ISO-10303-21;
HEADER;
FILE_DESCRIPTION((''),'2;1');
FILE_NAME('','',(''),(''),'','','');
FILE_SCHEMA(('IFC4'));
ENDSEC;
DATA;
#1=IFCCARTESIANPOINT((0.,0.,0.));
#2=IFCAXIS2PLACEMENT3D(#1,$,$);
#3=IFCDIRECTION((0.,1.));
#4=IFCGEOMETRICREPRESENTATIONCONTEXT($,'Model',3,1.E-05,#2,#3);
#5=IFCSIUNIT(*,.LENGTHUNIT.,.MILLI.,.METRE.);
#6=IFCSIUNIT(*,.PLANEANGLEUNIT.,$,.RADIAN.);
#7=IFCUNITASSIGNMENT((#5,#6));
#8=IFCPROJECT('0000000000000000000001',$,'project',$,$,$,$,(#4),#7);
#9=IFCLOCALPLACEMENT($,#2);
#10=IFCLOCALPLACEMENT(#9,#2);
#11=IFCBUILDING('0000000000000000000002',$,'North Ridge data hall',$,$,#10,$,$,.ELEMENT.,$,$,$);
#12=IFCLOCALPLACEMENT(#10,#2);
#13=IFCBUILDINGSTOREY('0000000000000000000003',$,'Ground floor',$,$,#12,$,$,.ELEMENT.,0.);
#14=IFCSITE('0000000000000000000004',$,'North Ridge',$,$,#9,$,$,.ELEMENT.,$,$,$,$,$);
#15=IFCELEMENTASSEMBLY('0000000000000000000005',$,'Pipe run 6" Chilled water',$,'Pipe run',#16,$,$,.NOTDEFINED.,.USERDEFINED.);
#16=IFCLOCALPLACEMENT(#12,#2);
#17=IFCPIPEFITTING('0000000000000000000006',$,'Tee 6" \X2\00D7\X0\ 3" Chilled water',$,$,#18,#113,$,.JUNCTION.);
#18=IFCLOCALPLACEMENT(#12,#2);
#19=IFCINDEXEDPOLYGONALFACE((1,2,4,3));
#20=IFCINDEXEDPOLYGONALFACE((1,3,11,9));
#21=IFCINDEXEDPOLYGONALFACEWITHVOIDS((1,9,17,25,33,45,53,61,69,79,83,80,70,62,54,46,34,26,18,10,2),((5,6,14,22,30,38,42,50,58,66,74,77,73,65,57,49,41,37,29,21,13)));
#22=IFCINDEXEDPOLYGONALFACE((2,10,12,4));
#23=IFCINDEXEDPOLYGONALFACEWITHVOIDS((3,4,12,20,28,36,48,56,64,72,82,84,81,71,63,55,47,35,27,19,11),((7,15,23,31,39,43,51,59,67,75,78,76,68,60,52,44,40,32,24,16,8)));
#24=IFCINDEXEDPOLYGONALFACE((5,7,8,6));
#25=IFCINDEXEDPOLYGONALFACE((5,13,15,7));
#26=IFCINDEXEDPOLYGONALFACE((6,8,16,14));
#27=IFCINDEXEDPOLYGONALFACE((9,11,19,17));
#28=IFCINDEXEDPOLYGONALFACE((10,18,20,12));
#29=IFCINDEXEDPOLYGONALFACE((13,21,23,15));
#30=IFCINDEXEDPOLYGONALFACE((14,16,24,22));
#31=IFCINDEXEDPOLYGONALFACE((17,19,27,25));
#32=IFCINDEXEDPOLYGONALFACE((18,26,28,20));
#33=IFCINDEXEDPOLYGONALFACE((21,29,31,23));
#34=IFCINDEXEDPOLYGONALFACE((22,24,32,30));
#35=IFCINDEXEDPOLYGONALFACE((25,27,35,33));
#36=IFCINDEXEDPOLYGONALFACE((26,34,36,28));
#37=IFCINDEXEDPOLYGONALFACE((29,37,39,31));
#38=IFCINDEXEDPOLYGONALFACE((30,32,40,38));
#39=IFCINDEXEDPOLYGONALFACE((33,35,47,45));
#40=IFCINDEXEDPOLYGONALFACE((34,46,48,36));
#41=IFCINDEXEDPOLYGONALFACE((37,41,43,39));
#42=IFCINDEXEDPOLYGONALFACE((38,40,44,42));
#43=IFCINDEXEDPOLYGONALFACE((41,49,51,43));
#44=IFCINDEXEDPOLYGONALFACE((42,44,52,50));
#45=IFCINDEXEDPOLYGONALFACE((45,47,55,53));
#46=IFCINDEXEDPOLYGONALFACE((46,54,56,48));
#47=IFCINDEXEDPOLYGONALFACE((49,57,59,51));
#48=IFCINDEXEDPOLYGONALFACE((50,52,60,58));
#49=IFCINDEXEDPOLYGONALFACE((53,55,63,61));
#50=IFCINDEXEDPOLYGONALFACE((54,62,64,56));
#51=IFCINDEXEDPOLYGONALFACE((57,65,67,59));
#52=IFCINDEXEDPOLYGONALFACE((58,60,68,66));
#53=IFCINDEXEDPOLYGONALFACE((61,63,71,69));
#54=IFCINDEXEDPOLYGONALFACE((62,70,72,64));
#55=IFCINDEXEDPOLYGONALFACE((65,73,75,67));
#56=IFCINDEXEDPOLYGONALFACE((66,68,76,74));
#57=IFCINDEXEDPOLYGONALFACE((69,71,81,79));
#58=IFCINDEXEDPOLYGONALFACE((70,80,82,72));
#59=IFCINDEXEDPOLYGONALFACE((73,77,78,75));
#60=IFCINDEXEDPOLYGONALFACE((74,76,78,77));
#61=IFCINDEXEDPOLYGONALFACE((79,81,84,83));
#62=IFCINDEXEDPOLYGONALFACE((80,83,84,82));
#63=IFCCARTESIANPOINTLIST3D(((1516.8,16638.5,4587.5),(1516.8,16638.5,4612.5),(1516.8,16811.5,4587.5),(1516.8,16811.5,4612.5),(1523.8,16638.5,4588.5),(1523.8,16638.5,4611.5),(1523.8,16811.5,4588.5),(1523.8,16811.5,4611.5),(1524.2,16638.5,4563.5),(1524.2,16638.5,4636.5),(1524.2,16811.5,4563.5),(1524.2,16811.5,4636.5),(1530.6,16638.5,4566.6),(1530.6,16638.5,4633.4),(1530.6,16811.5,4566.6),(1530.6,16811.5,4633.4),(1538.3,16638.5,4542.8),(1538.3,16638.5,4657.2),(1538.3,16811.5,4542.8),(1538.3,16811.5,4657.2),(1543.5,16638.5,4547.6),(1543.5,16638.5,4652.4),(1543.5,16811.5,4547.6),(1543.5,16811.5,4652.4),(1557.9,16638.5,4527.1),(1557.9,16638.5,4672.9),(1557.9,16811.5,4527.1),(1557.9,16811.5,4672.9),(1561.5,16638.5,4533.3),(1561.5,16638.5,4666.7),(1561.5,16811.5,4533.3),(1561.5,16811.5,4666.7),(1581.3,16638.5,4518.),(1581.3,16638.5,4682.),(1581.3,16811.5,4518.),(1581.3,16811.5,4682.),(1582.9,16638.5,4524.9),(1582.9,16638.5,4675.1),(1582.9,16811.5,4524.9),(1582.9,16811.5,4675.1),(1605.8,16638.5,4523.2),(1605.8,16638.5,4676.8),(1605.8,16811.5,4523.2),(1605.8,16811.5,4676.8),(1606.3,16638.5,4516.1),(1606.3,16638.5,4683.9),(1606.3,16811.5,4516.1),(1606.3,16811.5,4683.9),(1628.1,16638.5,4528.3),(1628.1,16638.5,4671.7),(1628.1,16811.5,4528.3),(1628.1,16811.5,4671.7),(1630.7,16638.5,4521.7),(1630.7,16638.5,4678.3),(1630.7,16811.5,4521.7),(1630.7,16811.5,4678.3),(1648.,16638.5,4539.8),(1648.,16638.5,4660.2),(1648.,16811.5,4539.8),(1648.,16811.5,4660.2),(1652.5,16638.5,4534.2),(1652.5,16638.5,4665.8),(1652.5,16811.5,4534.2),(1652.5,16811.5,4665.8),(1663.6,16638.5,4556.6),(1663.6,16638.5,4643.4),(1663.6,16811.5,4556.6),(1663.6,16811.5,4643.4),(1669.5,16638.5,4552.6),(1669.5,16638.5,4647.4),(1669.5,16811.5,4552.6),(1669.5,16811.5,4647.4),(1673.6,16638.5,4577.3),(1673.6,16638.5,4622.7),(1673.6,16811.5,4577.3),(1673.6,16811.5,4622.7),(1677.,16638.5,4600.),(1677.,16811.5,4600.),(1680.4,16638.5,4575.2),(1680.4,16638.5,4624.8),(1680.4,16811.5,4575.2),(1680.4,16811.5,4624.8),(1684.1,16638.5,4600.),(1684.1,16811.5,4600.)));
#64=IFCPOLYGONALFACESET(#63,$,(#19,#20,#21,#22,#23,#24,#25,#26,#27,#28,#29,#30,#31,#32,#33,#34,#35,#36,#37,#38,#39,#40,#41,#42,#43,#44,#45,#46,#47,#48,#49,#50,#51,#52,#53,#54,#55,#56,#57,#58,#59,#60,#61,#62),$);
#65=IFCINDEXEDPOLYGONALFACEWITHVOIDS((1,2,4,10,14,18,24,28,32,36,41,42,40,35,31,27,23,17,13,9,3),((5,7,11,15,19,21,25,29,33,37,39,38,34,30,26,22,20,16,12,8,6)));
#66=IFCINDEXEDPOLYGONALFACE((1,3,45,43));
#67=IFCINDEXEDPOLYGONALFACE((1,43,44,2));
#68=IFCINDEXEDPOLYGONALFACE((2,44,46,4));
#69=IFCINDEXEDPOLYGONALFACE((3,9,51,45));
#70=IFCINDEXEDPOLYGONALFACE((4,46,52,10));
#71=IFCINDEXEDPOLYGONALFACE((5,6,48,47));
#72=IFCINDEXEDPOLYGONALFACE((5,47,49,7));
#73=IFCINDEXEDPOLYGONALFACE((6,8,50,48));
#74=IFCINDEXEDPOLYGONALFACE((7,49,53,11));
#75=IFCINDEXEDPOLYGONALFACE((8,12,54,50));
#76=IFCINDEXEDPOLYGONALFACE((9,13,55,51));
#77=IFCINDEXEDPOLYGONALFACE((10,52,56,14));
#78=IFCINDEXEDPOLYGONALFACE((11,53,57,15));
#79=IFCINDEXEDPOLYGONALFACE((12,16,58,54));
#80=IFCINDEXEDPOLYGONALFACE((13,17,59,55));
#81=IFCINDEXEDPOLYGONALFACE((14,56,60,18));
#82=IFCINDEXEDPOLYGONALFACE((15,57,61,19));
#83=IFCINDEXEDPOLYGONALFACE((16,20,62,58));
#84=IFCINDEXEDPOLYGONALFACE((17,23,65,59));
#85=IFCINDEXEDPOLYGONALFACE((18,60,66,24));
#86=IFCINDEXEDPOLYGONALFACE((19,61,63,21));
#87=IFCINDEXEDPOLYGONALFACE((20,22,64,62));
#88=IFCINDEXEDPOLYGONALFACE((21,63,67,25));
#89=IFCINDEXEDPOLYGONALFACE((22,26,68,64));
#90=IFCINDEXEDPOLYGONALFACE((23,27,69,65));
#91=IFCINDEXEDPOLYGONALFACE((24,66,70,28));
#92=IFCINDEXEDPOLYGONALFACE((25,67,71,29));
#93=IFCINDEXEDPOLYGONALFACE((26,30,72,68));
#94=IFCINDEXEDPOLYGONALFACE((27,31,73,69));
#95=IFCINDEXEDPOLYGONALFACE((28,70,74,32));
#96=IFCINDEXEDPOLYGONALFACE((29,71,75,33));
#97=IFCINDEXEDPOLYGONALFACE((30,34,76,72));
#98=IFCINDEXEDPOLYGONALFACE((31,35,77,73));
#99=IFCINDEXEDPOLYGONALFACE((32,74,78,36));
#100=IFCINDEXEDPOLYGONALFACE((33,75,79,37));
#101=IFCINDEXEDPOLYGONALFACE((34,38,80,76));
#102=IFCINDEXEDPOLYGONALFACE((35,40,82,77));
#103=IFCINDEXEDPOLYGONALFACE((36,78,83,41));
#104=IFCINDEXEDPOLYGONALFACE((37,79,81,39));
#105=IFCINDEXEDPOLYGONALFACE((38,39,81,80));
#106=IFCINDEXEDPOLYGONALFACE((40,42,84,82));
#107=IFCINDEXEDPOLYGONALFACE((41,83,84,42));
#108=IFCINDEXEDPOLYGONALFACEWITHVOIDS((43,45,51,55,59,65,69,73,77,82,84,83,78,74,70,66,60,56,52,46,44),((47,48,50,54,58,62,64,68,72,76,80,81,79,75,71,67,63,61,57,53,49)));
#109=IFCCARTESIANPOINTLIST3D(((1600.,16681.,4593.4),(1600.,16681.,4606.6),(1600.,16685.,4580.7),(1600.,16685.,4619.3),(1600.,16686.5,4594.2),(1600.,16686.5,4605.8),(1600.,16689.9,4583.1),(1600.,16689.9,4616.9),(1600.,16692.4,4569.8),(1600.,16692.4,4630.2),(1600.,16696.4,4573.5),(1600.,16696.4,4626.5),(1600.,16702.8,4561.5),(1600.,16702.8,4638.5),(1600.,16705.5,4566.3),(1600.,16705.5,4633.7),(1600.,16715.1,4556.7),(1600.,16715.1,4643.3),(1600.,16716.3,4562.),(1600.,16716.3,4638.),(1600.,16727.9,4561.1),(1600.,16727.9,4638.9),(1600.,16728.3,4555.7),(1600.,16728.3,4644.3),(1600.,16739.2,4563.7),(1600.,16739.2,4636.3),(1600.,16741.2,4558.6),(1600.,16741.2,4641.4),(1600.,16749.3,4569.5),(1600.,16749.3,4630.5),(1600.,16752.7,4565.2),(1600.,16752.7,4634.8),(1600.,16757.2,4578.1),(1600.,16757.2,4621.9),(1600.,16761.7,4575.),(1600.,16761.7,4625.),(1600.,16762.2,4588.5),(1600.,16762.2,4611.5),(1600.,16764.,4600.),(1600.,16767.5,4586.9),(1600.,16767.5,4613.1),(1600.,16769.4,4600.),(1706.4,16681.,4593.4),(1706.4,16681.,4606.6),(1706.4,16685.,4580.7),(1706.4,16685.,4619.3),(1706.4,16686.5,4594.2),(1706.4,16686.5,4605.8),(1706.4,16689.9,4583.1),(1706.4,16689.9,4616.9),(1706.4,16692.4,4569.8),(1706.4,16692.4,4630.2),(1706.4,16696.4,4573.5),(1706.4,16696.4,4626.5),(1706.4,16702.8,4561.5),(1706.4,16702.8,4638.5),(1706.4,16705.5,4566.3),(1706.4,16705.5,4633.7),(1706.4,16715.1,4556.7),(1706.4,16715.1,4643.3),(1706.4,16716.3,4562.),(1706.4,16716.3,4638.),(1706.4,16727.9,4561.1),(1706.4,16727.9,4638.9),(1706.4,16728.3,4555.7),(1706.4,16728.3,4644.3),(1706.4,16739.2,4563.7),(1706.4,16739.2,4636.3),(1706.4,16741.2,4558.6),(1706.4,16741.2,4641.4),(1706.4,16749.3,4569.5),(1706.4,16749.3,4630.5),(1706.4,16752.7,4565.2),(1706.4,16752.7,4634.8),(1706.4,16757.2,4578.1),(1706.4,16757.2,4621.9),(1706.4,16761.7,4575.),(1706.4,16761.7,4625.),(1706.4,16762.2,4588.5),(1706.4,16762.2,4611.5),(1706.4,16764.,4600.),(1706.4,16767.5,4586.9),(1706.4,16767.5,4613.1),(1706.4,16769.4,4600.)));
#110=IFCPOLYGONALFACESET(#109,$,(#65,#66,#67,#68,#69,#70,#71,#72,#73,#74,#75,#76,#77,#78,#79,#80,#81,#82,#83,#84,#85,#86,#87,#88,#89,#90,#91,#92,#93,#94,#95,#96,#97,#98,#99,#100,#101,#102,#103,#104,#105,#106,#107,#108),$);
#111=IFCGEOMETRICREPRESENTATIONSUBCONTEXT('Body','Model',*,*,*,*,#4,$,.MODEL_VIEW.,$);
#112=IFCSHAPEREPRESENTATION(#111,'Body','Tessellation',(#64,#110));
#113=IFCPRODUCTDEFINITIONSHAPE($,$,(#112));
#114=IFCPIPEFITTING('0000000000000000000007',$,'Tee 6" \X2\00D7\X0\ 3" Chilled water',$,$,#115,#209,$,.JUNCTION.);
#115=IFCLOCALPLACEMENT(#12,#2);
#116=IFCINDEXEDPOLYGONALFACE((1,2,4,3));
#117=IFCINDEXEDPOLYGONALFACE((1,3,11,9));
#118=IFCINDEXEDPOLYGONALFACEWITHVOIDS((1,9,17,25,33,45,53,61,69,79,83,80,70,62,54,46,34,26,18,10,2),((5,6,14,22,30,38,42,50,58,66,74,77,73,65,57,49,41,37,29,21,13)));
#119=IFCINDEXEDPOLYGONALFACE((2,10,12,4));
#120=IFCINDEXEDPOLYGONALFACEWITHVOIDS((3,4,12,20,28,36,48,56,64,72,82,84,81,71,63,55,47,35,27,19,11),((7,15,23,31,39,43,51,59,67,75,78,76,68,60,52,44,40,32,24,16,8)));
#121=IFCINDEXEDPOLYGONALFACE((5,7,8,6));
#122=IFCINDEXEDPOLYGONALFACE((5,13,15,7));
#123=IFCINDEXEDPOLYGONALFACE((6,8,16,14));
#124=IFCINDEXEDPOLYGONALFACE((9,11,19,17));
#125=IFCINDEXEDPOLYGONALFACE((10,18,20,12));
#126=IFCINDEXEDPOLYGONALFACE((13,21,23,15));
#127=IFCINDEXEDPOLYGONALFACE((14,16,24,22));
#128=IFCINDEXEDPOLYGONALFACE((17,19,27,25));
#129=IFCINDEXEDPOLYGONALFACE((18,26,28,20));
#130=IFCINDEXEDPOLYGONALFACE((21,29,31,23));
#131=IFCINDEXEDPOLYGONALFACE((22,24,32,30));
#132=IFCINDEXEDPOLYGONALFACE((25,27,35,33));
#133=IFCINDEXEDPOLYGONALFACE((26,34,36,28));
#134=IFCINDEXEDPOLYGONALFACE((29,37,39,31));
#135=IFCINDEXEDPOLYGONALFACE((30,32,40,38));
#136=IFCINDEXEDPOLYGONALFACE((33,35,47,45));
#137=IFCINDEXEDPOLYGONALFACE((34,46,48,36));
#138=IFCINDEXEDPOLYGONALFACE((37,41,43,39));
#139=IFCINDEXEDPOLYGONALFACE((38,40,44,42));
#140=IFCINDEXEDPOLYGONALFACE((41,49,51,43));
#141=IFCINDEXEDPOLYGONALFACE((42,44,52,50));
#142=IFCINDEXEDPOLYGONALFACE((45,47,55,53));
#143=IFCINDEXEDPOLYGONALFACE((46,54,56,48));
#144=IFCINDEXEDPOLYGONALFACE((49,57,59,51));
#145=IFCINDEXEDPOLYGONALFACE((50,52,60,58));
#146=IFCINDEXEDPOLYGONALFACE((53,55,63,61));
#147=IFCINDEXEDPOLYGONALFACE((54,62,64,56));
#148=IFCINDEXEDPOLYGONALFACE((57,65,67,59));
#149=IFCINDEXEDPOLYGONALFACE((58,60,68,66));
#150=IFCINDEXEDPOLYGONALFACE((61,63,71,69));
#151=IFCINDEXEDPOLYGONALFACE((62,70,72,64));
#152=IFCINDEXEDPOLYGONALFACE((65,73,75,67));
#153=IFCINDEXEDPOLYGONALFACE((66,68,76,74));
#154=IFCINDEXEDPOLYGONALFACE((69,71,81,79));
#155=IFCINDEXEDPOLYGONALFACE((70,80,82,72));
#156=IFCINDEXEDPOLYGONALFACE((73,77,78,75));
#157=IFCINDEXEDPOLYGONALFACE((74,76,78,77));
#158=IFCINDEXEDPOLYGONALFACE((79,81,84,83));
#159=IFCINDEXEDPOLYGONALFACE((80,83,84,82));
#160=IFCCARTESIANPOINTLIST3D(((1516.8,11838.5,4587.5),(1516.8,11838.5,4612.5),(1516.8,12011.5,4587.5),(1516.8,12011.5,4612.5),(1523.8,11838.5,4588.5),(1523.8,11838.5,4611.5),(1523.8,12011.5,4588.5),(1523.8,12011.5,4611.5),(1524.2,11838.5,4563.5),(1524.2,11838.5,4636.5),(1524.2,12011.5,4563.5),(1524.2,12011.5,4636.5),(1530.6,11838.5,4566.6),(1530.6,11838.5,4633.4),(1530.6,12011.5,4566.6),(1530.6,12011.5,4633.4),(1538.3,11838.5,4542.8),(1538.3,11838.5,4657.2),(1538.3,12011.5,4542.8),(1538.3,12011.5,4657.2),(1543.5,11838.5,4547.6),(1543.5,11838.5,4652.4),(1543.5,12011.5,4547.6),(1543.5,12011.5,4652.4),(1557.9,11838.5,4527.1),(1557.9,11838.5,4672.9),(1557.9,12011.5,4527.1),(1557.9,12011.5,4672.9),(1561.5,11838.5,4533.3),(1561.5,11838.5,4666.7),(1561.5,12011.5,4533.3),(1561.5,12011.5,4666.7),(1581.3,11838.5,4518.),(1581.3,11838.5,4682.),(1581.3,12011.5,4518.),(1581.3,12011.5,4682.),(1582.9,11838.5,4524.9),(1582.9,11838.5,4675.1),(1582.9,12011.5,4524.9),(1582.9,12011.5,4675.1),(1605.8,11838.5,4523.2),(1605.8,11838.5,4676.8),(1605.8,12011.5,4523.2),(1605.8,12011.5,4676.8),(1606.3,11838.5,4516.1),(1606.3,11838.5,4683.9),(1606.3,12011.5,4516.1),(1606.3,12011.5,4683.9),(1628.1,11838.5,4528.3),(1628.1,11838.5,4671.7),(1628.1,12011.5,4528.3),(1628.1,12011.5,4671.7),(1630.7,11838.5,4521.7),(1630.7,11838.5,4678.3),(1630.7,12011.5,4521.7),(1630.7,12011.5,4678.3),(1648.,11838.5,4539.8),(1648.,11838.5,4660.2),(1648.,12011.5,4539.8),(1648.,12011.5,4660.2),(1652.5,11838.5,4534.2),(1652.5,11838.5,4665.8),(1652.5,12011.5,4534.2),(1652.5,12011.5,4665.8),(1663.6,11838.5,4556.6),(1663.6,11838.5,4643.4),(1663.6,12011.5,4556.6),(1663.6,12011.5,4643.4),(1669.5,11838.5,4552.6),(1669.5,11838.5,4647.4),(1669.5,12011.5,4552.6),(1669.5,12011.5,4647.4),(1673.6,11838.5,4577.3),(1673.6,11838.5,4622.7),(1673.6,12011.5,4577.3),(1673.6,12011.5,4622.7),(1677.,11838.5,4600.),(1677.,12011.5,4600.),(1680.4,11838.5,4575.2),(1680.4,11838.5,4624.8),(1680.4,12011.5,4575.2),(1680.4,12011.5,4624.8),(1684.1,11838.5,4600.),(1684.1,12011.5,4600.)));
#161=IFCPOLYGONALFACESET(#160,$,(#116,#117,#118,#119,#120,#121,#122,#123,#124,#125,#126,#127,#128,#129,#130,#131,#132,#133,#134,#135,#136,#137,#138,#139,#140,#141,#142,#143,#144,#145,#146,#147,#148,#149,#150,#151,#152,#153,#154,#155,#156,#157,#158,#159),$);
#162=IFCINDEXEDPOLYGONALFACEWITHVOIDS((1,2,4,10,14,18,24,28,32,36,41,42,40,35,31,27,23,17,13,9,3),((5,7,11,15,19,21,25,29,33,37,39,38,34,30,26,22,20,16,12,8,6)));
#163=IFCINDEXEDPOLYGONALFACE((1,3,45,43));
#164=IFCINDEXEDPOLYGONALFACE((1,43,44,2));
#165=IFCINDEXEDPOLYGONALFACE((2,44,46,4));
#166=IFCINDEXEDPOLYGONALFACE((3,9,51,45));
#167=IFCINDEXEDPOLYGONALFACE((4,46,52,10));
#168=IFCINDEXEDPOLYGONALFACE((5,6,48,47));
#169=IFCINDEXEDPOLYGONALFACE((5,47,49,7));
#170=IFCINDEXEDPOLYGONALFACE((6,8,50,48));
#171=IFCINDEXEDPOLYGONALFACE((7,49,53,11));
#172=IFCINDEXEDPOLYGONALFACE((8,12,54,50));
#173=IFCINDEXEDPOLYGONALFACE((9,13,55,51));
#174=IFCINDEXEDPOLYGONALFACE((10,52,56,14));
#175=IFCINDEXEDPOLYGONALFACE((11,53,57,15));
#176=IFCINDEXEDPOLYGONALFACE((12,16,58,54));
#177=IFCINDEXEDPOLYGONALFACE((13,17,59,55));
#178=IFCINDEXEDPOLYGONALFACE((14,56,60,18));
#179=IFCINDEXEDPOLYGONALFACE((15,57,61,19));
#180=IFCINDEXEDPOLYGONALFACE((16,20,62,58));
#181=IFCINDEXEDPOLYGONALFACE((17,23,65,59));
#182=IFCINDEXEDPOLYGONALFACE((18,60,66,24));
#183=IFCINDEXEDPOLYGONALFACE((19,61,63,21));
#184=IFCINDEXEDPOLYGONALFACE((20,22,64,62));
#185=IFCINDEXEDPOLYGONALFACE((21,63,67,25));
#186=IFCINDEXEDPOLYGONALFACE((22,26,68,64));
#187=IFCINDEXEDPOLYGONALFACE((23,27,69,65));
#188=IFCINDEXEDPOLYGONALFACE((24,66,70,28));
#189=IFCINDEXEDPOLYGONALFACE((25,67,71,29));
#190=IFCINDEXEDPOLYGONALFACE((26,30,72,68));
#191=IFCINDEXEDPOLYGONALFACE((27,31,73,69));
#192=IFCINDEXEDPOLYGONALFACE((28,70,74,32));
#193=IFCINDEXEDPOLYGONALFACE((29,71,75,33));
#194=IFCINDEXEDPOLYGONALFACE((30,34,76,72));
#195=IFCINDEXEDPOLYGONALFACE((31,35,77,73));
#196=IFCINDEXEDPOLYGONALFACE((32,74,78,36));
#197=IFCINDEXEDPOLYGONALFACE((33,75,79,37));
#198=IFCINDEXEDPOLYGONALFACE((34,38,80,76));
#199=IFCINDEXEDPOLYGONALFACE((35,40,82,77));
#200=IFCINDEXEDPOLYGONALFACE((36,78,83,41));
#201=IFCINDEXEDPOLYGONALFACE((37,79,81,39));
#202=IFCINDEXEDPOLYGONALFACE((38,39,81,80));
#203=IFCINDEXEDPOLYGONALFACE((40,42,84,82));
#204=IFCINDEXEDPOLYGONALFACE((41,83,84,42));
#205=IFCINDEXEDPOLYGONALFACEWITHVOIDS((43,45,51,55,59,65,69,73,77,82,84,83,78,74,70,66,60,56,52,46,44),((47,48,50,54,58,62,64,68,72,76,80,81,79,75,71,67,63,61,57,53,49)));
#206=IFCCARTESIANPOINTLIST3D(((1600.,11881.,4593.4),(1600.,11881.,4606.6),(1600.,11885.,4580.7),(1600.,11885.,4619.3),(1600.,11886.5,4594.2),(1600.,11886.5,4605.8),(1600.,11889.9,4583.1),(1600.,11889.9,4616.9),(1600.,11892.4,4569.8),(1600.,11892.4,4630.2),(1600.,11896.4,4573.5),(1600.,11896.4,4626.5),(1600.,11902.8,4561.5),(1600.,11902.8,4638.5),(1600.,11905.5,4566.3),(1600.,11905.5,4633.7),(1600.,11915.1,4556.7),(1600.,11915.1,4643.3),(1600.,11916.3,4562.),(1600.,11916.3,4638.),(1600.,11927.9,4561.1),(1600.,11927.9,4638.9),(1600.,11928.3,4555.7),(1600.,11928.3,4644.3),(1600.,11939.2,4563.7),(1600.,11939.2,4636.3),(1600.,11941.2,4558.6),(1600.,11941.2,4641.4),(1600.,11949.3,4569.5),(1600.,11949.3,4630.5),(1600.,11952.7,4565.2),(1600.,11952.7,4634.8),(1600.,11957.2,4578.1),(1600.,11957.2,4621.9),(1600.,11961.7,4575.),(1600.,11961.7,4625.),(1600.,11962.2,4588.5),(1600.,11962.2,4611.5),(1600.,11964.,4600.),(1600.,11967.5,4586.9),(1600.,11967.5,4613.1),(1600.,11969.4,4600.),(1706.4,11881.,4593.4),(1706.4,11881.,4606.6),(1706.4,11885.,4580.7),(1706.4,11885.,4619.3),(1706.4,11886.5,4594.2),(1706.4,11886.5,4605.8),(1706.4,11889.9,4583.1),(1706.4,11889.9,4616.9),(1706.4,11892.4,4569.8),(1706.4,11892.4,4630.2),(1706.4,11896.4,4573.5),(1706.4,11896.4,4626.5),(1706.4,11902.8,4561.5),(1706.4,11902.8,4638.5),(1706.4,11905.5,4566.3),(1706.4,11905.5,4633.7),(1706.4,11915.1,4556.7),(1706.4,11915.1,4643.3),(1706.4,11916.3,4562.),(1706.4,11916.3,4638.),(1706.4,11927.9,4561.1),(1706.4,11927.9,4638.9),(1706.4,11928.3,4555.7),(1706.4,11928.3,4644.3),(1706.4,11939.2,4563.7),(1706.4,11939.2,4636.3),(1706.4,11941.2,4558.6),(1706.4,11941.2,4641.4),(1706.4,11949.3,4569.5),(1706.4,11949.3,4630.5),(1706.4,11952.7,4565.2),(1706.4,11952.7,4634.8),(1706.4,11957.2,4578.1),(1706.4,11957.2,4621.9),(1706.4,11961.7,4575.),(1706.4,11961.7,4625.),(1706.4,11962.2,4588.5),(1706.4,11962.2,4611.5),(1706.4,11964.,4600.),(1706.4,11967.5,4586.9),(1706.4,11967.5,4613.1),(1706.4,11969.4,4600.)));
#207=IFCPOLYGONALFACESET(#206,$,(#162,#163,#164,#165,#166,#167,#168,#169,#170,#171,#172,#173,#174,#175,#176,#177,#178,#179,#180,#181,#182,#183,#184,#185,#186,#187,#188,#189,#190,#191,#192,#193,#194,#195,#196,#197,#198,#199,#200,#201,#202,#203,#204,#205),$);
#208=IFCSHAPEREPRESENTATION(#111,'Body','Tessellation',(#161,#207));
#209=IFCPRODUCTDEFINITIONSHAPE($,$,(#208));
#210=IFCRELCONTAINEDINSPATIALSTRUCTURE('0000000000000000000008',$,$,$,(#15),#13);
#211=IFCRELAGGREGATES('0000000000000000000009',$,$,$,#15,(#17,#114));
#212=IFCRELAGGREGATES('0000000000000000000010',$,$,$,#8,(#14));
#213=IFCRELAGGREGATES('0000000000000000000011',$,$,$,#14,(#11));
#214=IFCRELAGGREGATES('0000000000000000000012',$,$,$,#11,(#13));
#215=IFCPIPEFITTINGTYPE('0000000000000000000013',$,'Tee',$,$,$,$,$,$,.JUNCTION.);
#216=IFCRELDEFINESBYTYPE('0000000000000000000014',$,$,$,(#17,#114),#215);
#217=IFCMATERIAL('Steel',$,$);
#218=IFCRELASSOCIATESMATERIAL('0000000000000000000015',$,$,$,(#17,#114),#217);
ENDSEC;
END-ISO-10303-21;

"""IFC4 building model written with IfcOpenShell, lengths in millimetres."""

from ifc_helpers import new_model, si_unit, direction, frame, origin, origin_with_axes, origin_2d, place, context, subcontext, project, spatial, hollow_circle, extrude, material, type_object, element, aggregate, save


model = new_model("IFC4")

# Units and contexts
model_context = context("Model", 3, precision=1e-05, world=origin(), true_north=direction((0.0, 1.0)))
body_context = subcontext(model_context, "Body", "Model", "MODEL_VIEW")
ifc_project = project(units=[si_unit("LENGTHUNIT", "METRE", prefix="MILLI"), si_unit("PLANEANGLEUNIT", "RADIAN")], contexts=[model_context])

# Site, building, storey
site_placement = place(None, origin())
site = spatial("IfcSite", under=ifc_project, at=site_placement, Name="North Ridge", CompositionType="ELEMENT")
building_placement = place(site_placement, origin())
building = spatial("IfcBuilding", under=site, at=building_placement, Name="North Ridge data hall", CompositionType="ELEMENT")
storey_placement = place(building_placement, origin())
storey = spatial("IfcBuildingStorey", under=building, at=storey_placement, Name="Ground floor", CompositionType="ELEMENT", Elevation=0.0)

# Element assembly
ifc_material_1 = material(Name="Steel")
assembly_1_placement = place(storey_placement, origin_with_axes())
assembly_1 = element("IfcElementAssembly", 1, at=assembly_1_placement, inside=storey, Name="Pipe run 6\" Chilled water", ObjectType="Pipe run", AssemblyPlace="NOTDEFINED", PredefinedType="USERDEFINED")

# Pipe fittings
pipe_fitting_type_1 = type_object("IfcPipeFittingType", Name="Tee", PredefinedType="JUNCTION")
pipe_fitting_1_placement = place(storey_placement, origin_with_axes())
pipe_fitting_1 = element("IfcPipeFitting", 2, at=pipe_fitting_1_placement, type_object=pipe_fitting_type_1, material=ifc_material_1, Name="Tee 6\" × 3\" Chilled water", PredefinedType="JUNCTION", context=body_context, shape_type="SweptSolid", body=[
    extrude(hollow_circle(Radius=84.1, WallThickness=7.1, at=origin_2d()), frame((1600.0, 16811.5, 4600.0), z_axis=(0.0, -1.0, 0.0), x_axis=(1.0, 0.0, 0.0)), (0.0, 0.0, 1.0), 173.0),
    extrude(hollow_circle(Radius=44.5, WallThickness=5.5, at=origin_2d()), frame((1600.0, 16725.0, 4600.0), z_axis=(1.0, 0.0, 0.0), x_axis=(0.0, 1.0, 0.0)), (0.0, 0.0, 1.0), 106.4),
])
pipe_fitting_2_placement = place(storey_placement, origin_with_axes())
pipe_fitting_2 = element("IfcPipeFitting", 3, at=pipe_fitting_2_placement, type_object=pipe_fitting_type_1, material=ifc_material_1, Name="Tee 6\" × 3\" Chilled water", PredefinedType="JUNCTION", context=body_context, shape_type="SweptSolid", body=[
    extrude(hollow_circle(Radius=84.1, WallThickness=7.1, at=origin_2d()), frame((1600.0, 12011.5, 4600.0), z_axis=(0.0, -1.0, 0.0), x_axis=(1.0, 0.0, 0.0)), (0.0, 0.0, 1.0), 173.0),
    extrude(hollow_circle(Radius=44.5, WallThickness=5.5, at=origin_2d()), frame((1600.0, 11925.0, 4600.0), z_axis=(1.0, 0.0, 0.0), x_axis=(0.0, 1.0, 0.0)), (0.0, 0.0, 1.0), 106.4),
])
aggregate(assembly_1, [pipe_fitting_1, pipe_fitting_2])

save(model, "model.ifc")
